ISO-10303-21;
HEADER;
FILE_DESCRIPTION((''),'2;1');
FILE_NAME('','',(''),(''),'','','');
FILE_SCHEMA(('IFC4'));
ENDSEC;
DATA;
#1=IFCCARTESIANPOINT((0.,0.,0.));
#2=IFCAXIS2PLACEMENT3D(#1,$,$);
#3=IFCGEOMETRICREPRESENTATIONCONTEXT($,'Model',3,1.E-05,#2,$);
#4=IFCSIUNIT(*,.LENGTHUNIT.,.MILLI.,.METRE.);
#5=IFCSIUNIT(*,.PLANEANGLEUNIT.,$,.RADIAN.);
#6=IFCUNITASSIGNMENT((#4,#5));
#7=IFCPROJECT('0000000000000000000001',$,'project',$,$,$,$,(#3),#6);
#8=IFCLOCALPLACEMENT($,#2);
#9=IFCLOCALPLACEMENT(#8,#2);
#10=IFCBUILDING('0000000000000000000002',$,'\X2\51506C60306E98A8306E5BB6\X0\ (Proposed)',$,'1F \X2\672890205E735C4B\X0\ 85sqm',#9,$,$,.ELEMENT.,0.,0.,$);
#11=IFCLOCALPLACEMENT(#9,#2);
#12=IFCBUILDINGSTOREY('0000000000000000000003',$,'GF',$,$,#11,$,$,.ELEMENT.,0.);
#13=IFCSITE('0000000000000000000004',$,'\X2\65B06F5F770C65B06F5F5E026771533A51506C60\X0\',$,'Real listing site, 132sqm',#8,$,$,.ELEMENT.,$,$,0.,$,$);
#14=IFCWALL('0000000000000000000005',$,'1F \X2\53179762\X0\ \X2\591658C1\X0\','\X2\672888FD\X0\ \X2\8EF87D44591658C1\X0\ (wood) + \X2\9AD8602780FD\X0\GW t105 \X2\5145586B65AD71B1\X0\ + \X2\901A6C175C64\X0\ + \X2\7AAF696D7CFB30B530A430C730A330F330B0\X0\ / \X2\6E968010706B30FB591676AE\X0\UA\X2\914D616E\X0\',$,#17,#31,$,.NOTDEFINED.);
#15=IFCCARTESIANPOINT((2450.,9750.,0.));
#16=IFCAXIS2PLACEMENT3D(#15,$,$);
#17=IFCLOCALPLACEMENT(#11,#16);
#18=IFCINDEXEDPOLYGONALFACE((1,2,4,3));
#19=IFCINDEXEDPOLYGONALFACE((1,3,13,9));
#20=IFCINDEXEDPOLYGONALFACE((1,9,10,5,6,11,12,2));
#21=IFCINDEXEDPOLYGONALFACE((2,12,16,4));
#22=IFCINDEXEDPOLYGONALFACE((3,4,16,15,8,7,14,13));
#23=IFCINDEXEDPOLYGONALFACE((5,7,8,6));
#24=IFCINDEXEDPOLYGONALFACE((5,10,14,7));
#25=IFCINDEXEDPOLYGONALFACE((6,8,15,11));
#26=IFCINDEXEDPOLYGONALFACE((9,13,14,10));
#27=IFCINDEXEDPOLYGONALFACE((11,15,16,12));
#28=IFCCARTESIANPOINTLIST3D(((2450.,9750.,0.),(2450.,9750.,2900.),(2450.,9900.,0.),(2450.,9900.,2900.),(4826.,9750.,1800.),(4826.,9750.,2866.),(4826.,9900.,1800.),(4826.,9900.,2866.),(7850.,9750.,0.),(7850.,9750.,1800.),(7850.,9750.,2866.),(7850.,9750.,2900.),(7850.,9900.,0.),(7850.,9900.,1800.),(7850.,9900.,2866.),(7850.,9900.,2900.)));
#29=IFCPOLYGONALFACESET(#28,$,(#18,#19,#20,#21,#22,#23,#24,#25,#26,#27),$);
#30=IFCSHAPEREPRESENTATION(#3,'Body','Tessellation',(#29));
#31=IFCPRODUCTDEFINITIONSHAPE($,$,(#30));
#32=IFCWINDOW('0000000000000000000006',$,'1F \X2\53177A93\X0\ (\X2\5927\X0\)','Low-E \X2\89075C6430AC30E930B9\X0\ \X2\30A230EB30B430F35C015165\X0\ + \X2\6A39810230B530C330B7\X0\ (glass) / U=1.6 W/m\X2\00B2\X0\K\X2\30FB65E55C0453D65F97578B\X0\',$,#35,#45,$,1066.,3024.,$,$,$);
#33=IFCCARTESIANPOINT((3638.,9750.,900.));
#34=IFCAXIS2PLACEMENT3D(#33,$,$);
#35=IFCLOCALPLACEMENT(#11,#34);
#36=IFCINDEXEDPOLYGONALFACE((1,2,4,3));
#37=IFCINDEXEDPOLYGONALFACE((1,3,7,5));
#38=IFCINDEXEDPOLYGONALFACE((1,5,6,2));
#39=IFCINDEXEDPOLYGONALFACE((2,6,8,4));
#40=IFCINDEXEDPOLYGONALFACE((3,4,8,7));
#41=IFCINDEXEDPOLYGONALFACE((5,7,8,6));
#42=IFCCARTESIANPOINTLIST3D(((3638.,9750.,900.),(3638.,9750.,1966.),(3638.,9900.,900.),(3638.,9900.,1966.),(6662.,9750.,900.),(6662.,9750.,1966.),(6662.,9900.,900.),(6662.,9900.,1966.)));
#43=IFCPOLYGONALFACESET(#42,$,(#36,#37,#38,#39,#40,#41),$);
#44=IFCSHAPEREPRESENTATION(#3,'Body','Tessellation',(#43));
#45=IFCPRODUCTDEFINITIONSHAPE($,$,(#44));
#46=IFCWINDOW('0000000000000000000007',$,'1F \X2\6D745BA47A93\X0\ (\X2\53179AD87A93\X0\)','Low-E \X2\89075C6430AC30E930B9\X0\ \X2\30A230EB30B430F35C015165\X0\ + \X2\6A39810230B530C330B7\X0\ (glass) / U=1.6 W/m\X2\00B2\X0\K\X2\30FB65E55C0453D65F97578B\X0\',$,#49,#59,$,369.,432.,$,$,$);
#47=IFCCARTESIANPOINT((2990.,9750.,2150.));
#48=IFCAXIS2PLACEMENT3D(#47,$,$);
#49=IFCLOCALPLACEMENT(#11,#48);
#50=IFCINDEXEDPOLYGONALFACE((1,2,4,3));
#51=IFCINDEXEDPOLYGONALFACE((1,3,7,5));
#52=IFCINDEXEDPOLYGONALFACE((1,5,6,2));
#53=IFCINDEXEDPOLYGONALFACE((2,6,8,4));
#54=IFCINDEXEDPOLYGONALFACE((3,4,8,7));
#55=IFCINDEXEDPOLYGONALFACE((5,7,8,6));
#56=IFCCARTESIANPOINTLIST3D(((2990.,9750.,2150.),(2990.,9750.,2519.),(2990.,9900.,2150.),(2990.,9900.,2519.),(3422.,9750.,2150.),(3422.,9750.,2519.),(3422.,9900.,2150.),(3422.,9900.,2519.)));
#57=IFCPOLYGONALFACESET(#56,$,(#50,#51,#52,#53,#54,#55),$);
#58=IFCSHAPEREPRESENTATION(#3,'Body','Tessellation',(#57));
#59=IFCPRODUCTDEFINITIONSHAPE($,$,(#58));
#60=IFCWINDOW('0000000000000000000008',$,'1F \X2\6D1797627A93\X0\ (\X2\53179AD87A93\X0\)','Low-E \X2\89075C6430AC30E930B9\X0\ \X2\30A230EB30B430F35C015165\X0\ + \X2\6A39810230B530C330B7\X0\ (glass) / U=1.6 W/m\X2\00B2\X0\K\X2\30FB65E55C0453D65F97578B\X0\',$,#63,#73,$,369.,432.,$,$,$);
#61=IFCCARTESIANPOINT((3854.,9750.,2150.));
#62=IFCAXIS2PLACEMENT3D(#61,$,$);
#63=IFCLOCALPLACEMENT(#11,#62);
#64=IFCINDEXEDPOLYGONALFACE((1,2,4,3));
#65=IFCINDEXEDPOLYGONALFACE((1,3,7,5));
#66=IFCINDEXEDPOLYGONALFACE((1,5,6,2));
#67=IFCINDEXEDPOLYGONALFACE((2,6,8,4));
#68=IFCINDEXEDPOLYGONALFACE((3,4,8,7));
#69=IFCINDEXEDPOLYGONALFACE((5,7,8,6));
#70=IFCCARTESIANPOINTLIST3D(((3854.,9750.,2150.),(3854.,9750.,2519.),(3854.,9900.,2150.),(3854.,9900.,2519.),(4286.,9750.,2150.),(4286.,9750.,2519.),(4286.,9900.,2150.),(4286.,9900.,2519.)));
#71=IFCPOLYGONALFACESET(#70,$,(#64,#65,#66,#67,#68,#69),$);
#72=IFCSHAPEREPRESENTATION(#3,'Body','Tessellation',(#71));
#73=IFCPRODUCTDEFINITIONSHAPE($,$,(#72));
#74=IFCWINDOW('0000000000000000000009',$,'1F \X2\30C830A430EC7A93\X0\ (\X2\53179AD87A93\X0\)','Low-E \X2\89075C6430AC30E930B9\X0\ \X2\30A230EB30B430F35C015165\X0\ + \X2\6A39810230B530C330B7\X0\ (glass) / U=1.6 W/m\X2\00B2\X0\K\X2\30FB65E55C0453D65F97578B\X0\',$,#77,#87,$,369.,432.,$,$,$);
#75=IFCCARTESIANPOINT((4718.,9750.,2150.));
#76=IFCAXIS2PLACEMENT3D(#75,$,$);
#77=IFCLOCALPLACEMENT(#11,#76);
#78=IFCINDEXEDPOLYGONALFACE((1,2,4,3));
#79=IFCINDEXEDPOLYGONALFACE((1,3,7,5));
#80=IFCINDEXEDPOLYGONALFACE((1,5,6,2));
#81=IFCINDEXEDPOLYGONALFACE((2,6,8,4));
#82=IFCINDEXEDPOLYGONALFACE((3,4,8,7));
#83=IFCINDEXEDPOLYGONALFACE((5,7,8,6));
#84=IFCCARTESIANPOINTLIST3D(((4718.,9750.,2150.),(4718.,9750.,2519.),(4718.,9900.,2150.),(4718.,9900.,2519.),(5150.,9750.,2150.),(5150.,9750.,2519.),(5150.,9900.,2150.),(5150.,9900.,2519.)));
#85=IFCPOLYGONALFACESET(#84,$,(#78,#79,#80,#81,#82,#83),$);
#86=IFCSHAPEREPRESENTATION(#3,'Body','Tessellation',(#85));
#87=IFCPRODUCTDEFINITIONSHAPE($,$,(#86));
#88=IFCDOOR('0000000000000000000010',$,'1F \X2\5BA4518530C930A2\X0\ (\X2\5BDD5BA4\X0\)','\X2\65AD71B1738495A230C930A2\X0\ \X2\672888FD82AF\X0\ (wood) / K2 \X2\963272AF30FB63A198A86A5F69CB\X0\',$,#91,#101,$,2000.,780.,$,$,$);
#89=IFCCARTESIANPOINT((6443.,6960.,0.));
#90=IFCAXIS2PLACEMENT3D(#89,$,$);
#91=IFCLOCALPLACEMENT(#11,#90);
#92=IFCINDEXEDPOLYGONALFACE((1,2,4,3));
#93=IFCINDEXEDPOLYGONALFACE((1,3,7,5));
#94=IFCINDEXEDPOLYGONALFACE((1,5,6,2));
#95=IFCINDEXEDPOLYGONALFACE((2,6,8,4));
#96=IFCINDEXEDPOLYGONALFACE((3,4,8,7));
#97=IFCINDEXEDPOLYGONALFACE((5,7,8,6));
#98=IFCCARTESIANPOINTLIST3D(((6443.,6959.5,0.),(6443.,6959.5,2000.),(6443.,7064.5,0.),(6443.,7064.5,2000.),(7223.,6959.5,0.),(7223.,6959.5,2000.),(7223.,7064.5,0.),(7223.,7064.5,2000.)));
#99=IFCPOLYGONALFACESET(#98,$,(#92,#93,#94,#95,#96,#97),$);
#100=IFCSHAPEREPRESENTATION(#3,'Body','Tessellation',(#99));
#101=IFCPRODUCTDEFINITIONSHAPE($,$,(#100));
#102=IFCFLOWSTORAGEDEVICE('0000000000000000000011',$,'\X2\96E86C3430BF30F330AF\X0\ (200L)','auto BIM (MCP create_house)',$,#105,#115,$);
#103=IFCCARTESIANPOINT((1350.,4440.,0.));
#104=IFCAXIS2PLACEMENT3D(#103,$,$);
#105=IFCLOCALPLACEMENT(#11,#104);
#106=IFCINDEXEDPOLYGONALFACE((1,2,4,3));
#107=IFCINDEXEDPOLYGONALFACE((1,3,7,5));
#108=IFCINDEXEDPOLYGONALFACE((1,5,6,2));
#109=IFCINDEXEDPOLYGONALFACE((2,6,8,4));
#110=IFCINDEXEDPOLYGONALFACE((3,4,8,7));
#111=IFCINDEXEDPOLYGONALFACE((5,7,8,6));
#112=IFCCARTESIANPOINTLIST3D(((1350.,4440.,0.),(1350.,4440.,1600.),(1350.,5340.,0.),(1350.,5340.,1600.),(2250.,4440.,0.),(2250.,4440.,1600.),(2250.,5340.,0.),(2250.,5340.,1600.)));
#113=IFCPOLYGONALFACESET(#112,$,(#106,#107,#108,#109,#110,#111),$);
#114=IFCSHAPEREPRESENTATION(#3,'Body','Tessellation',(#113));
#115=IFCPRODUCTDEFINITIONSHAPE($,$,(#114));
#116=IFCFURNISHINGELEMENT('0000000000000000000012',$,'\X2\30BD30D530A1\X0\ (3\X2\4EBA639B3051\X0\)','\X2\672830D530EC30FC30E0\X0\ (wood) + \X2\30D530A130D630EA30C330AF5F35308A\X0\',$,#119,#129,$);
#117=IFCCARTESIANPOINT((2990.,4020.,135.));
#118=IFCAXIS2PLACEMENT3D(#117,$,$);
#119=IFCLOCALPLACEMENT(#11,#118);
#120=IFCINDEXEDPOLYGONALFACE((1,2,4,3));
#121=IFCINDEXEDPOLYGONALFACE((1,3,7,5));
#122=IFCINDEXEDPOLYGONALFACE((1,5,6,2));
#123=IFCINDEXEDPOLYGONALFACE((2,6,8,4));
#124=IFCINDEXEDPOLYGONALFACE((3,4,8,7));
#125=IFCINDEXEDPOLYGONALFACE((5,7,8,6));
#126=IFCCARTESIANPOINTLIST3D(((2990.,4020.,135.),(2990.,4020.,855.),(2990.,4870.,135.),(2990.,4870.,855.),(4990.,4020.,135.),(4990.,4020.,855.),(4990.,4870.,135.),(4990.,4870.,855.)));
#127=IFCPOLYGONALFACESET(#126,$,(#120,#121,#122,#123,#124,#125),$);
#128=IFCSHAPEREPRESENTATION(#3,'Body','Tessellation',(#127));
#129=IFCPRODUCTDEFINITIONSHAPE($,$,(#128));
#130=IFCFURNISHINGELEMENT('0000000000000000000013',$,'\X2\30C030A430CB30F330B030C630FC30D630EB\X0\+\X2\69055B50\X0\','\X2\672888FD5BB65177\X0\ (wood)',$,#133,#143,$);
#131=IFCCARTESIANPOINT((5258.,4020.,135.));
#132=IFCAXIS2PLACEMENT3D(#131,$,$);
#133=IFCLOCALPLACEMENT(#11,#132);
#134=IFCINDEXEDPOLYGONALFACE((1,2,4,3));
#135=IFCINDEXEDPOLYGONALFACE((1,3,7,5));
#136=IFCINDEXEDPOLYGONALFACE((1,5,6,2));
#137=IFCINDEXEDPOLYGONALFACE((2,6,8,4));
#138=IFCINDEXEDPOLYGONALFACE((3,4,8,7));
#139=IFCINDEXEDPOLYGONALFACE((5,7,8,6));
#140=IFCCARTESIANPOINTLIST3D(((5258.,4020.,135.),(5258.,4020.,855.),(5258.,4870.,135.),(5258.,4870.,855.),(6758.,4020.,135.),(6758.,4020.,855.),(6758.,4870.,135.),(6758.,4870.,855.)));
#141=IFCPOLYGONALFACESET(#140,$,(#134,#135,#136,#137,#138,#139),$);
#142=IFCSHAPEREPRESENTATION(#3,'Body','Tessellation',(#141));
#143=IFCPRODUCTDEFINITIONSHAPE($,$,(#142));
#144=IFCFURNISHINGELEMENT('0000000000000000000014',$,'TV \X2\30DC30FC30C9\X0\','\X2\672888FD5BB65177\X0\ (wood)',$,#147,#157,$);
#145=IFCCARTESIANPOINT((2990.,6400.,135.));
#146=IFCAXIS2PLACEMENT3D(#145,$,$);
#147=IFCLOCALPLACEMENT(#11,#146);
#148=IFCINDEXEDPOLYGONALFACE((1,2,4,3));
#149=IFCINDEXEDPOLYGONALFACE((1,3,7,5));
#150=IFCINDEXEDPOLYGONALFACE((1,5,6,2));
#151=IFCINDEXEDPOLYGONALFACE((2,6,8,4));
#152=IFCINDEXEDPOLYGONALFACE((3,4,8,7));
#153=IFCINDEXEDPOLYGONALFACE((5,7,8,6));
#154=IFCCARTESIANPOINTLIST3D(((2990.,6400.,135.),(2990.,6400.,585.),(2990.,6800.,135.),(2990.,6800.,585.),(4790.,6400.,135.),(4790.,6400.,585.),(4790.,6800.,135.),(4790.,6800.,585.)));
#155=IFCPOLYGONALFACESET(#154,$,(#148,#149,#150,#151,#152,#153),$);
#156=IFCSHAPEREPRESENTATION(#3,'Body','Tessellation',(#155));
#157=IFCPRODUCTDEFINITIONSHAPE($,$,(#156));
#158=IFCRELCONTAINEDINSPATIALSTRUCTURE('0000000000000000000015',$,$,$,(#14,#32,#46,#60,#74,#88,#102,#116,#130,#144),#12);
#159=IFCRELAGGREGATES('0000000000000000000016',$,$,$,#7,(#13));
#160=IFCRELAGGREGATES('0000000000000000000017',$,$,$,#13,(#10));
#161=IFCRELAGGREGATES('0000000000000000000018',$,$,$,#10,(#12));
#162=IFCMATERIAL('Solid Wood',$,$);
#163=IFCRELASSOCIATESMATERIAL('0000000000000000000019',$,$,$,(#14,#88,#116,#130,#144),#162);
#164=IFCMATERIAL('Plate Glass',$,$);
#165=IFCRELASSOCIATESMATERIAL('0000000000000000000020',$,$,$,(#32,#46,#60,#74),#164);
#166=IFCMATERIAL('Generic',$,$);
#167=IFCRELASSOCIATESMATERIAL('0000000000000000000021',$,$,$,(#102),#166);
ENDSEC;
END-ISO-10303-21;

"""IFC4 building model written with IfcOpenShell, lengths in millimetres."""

from ifc_helpers import new_model, si_unit, frame, frame_2d, origin, place, context, project, spatial, rectangle, extrude, material, element, fill, save


model = new_model("IFC4")

# Units and contexts
model_context = context("Model", 3, precision=1e-05, world=origin())
ifc_project = project(units=[si_unit("LENGTHUNIT", "METRE", prefix="MILLI"), si_unit("PLANEANGLEUNIT", "RADIAN")], contexts=[model_context])

# Site, building, storey
site_placement = place(None, origin())
site = spatial("IfcSite", under=ifc_project, at=site_placement, Name="新潟県新潟市東区児池", ObjectType="Real listing site, 132sqm", CompositionType="ELEMENT", RefElevation=0.0)
building_placement = place(site_placement, origin())
building = spatial("IfcBuilding", under=site, at=building_placement, Name="児池の風の家 (Proposed)", ObjectType="1F 木造平屋 85sqm", CompositionType="ELEMENT", ElevationOfRefHeight=0.0, ElevationOfTerrain=0.0)
storey_placement = place(building_placement, origin())
storey = spatial("IfcBuildingStorey", under=building, at=storey_placement, Name="GF", CompositionType="ELEMENT", Elevation=0.0)

# Wall, openings, windows
ifc_material_1 = material(Name="Solid Wood")
wall_1_placement = place(storey_placement, frame((2450.0, 9750.0, 0.0)))
wall_1 = element("IfcWall", 1, at=wall_1_placement, inside=storey, material=ifc_material_1, Name="1F 北面 外壁", Description="木製 軸組外壁 (wood) + 高性能GW t105 充填断熱 + 通気層 + 窯業系サイディング / 準耐火・外皮UA配慮", PredefinedType="NOTDEFINED", context=model_context, shape_type="SweptSolid", body=[
    extrude(rectangle(XDim=5400.0, YDim=150.0, at=frame_2d((2700.0, 75.0))), frame((2450.0, 9750.0, 0.0)), (0.0, 0.0, 1.0), 2900.0),
])
opening_1_placement = place(storey_placement, frame((3638.0, 9750.0, 900.0)))
opening_1 = element("IfcOpeningElement", 2, at=opening_1_placement, cuts=wall_1, PredefinedType="NOTDEFINED", context=model_context, shape_type="SweptSolid", body=[
    extrude(rectangle(XDim=3024.0, YDim=150.0, at=frame_2d((1512.0, 75.0))), frame((3638.0, 9750.0, 900.0)), (0.0, 0.0, 1.0), 1066.0),
])
opening_2_placement = place(storey_placement, frame((2990.0, 9750.0, 2150.0)))
opening_2 = element("IfcOpeningElement", 3, at=opening_2_placement, cuts=wall_1, PredefinedType="NOTDEFINED", context=model_context, shape_type="SweptSolid", body=[
    extrude(rectangle(XDim=432.0, YDim=150.0, at=frame_2d((216.0, 75.0))), frame((2990.0, 9750.0, 2150.0)), (0.0, 0.0, 1.0), 369.0),
])
opening_3_placement = place(storey_placement, frame((3854.0, 9750.0, 2150.0)))
opening_3 = element("IfcOpeningElement", 4, at=opening_3_placement, cuts=wall_1, PredefinedType="NOTDEFINED", context=model_context, shape_type="SweptSolid", body=[
    extrude(rectangle(XDim=432.0, YDim=150.0, at=frame_2d((216.0, 75.0))), frame((3854.0, 9750.0, 2150.0)), (0.0, 0.0, 1.0), 369.0),
])
opening_4_placement = place(storey_placement, frame((4718.0, 9750.0, 2150.0)))
opening_4 = element("IfcOpeningElement", 5, at=opening_4_placement, cuts=wall_1, PredefinedType="NOTDEFINED", context=model_context, shape_type="SweptSolid", body=[
    extrude(rectangle(XDim=432.0, YDim=150.0, at=frame_2d((216.0, 75.0))), frame((4718.0, 9750.0, 2150.0)), (0.0, 0.0, 1.0), 369.0),
])
ifc_material_2 = material(Name="Plate Glass")
window_1_placement = place(storey_placement, frame((3638.0, 9750.0, 900.0)))
window_1 = element("IfcWindow", 6, at=window_1_placement, inside=storey, material=ifc_material_2, Name="1F 北窓 (大)", Description="Low-E 複層ガラス アルゴン封入 + 樹脂サッシ (glass) / U=1.6 W/m²K・日射取得型", OverallHeight=1066.0, OverallWidth=3024.0, context=model_context, shape_type="SweptSolid", body=[
    extrude(rectangle(XDim=3024.0, YDim=150.0, at=frame_2d((1512.0, 75.0))), frame((3638.0, 9750.0, 900.0)), (0.0, 0.0, 1.0), 1066.0),
])
fill(opening_1, window_1)
window_2_placement = place(storey_placement, frame((2990.0, 9750.0, 2150.0)))
window_2 = element("IfcWindow", 7, at=window_2_placement, inside=storey, material=ifc_material_2, Name="1F 浴室窓 (北高窓)", Description="Low-E 複層ガラス アルゴン封入 + 樹脂サッシ (glass) / U=1.6 W/m²K・日射取得型", OverallHeight=369.0, OverallWidth=432.0, context=model_context, shape_type="SweptSolid", body=[
    extrude(rectangle(XDim=432.0, YDim=150.0, at=frame_2d((216.0, 75.0))), frame((2990.0, 9750.0, 2150.0)), (0.0, 0.0, 1.0), 369.0),
])
fill(opening_2, window_2)
window_3_placement = place(storey_placement, frame((3854.0, 9750.0, 2150.0)))
window_3 = element("IfcWindow", 8, at=window_3_placement, inside=storey, material=ifc_material_2, Name="1F 洗面窓 (北高窓)", Description="Low-E 複層ガラス アルゴン封入 + 樹脂サッシ (glass) / U=1.6 W/m²K・日射取得型", OverallHeight=369.0, OverallWidth=432.0, context=model_context, shape_type="SweptSolid", body=[
    extrude(rectangle(XDim=432.0, YDim=150.0, at=frame_2d((216.0, 75.0))), frame((3854.0, 9750.0, 2150.0)), (0.0, 0.0, 1.0), 369.0),
])
fill(opening_3, window_3)
window_4_placement = place(storey_placement, frame((4718.0, 9750.0, 2150.0)))
window_4 = element("IfcWindow", 9, at=window_4_placement, inside=storey, material=ifc_material_2, Name="1F トイレ窓 (北高窓)", Description="Low-E 複層ガラス アルゴン封入 + 樹脂サッシ (glass) / U=1.6 W/m²K・日射取得型", OverallHeight=369.0, OverallWidth=432.0, context=model_context, shape_type="SweptSolid", body=[
    extrude(rectangle(XDim=432.0, YDim=150.0, at=frame_2d((216.0, 75.0))), frame((4718.0, 9750.0, 2150.0)), (0.0, 0.0, 1.0), 369.0),
])
fill(opening_4, window_4)

# Door
door_1_placement = place(storey_placement, frame((6443.0, 6960.0, 0.0)))
element("IfcDoor", 10, at=door_1_placement, inside=storey, material=ifc_material_1, Name="1F 室内ドア (寝室)", Description="断熱玄関ドア 木製芯 (wood) / K2 防犯・採風機構", OverallHeight=2000.0, OverallWidth=780.0, context=model_context, shape_type="SweptSolid", body=[
    extrude(rectangle(XDim=780.0, YDim=105.0, at=frame_2d((390.0, 52.0))), frame((6443.0, 6960.0, 0.0)), (0.0, 0.0, 1.0), 2000.0),
])

# Flow storage device
ifc_material_3 = material(Name="Generic")
flow_storage_device_placement = place(storey_placement, frame((1350.0, 4440.0, 0.0)))
element("IfcFlowStorageDevice", 11, at=flow_storage_device_placement, inside=storey, material=ifc_material_3, Name="雨水タンク (200L)", Description="auto BIM (MCP create_house)", context=model_context, shape_type="SweptSolid", body=[
    extrude(rectangle(XDim=900.0, YDim=900.0, at=frame_2d((450.0, 450.0))), frame((1350.0, 4440.0, 0.0)), (0.0, 0.0, 1.0), 1600.0),
])

# Furnishing elements
furnishing_1_placement = place(storey_placement, frame((2990.0, 4020.0, 135.0)))
element("IfcFurnishingElement", 12, at=furnishing_1_placement, inside=storey, material=ifc_material_1, Name="ソファ (3人掛け)", Description="木フレーム (wood) + ファブリック張り", context=model_context, shape_type="SweptSolid", body=[
    extrude(rectangle(XDim=2000.0, YDim=850.0, at=frame_2d((1000.0, 425.0))), frame((2990.0, 4020.0, 135.0)), (0.0, 0.0, 1.0), 720.0),
])
furnishing_2_placement = place(storey_placement, frame((5258.0, 4020.0, 135.0)))
element("IfcFurnishingElement", 13, at=furnishing_2_placement, inside=storey, material=ifc_material_1, Name="ダイニングテーブル+椅子", Description="木製家具 (wood)", context=model_context, shape_type="SweptSolid", body=[
    extrude(rectangle(XDim=1500.0, YDim=850.0, at=frame_2d((750.0, 425.0))), frame((5258.0, 4020.0, 135.0)), (0.0, 0.0, 1.0), 720.0),
])
furnishing_3_placement = place(storey_placement, frame((2990.0, 6400.0, 135.0)))
element("IfcFurnishingElement", 14, at=furnishing_3_placement, inside=storey, material=ifc_material_1, Name="TV ボード", Description="木製家具 (wood)", context=model_context, shape_type="SweptSolid", body=[
    extrude(rectangle(XDim=1800.0, YDim=400.0, at=frame_2d((900.0, 200.0))), frame((2990.0, 6400.0, 135.0)), (0.0, 0.0, 1.0), 450.0),
])

save(model, "model.ifc")
